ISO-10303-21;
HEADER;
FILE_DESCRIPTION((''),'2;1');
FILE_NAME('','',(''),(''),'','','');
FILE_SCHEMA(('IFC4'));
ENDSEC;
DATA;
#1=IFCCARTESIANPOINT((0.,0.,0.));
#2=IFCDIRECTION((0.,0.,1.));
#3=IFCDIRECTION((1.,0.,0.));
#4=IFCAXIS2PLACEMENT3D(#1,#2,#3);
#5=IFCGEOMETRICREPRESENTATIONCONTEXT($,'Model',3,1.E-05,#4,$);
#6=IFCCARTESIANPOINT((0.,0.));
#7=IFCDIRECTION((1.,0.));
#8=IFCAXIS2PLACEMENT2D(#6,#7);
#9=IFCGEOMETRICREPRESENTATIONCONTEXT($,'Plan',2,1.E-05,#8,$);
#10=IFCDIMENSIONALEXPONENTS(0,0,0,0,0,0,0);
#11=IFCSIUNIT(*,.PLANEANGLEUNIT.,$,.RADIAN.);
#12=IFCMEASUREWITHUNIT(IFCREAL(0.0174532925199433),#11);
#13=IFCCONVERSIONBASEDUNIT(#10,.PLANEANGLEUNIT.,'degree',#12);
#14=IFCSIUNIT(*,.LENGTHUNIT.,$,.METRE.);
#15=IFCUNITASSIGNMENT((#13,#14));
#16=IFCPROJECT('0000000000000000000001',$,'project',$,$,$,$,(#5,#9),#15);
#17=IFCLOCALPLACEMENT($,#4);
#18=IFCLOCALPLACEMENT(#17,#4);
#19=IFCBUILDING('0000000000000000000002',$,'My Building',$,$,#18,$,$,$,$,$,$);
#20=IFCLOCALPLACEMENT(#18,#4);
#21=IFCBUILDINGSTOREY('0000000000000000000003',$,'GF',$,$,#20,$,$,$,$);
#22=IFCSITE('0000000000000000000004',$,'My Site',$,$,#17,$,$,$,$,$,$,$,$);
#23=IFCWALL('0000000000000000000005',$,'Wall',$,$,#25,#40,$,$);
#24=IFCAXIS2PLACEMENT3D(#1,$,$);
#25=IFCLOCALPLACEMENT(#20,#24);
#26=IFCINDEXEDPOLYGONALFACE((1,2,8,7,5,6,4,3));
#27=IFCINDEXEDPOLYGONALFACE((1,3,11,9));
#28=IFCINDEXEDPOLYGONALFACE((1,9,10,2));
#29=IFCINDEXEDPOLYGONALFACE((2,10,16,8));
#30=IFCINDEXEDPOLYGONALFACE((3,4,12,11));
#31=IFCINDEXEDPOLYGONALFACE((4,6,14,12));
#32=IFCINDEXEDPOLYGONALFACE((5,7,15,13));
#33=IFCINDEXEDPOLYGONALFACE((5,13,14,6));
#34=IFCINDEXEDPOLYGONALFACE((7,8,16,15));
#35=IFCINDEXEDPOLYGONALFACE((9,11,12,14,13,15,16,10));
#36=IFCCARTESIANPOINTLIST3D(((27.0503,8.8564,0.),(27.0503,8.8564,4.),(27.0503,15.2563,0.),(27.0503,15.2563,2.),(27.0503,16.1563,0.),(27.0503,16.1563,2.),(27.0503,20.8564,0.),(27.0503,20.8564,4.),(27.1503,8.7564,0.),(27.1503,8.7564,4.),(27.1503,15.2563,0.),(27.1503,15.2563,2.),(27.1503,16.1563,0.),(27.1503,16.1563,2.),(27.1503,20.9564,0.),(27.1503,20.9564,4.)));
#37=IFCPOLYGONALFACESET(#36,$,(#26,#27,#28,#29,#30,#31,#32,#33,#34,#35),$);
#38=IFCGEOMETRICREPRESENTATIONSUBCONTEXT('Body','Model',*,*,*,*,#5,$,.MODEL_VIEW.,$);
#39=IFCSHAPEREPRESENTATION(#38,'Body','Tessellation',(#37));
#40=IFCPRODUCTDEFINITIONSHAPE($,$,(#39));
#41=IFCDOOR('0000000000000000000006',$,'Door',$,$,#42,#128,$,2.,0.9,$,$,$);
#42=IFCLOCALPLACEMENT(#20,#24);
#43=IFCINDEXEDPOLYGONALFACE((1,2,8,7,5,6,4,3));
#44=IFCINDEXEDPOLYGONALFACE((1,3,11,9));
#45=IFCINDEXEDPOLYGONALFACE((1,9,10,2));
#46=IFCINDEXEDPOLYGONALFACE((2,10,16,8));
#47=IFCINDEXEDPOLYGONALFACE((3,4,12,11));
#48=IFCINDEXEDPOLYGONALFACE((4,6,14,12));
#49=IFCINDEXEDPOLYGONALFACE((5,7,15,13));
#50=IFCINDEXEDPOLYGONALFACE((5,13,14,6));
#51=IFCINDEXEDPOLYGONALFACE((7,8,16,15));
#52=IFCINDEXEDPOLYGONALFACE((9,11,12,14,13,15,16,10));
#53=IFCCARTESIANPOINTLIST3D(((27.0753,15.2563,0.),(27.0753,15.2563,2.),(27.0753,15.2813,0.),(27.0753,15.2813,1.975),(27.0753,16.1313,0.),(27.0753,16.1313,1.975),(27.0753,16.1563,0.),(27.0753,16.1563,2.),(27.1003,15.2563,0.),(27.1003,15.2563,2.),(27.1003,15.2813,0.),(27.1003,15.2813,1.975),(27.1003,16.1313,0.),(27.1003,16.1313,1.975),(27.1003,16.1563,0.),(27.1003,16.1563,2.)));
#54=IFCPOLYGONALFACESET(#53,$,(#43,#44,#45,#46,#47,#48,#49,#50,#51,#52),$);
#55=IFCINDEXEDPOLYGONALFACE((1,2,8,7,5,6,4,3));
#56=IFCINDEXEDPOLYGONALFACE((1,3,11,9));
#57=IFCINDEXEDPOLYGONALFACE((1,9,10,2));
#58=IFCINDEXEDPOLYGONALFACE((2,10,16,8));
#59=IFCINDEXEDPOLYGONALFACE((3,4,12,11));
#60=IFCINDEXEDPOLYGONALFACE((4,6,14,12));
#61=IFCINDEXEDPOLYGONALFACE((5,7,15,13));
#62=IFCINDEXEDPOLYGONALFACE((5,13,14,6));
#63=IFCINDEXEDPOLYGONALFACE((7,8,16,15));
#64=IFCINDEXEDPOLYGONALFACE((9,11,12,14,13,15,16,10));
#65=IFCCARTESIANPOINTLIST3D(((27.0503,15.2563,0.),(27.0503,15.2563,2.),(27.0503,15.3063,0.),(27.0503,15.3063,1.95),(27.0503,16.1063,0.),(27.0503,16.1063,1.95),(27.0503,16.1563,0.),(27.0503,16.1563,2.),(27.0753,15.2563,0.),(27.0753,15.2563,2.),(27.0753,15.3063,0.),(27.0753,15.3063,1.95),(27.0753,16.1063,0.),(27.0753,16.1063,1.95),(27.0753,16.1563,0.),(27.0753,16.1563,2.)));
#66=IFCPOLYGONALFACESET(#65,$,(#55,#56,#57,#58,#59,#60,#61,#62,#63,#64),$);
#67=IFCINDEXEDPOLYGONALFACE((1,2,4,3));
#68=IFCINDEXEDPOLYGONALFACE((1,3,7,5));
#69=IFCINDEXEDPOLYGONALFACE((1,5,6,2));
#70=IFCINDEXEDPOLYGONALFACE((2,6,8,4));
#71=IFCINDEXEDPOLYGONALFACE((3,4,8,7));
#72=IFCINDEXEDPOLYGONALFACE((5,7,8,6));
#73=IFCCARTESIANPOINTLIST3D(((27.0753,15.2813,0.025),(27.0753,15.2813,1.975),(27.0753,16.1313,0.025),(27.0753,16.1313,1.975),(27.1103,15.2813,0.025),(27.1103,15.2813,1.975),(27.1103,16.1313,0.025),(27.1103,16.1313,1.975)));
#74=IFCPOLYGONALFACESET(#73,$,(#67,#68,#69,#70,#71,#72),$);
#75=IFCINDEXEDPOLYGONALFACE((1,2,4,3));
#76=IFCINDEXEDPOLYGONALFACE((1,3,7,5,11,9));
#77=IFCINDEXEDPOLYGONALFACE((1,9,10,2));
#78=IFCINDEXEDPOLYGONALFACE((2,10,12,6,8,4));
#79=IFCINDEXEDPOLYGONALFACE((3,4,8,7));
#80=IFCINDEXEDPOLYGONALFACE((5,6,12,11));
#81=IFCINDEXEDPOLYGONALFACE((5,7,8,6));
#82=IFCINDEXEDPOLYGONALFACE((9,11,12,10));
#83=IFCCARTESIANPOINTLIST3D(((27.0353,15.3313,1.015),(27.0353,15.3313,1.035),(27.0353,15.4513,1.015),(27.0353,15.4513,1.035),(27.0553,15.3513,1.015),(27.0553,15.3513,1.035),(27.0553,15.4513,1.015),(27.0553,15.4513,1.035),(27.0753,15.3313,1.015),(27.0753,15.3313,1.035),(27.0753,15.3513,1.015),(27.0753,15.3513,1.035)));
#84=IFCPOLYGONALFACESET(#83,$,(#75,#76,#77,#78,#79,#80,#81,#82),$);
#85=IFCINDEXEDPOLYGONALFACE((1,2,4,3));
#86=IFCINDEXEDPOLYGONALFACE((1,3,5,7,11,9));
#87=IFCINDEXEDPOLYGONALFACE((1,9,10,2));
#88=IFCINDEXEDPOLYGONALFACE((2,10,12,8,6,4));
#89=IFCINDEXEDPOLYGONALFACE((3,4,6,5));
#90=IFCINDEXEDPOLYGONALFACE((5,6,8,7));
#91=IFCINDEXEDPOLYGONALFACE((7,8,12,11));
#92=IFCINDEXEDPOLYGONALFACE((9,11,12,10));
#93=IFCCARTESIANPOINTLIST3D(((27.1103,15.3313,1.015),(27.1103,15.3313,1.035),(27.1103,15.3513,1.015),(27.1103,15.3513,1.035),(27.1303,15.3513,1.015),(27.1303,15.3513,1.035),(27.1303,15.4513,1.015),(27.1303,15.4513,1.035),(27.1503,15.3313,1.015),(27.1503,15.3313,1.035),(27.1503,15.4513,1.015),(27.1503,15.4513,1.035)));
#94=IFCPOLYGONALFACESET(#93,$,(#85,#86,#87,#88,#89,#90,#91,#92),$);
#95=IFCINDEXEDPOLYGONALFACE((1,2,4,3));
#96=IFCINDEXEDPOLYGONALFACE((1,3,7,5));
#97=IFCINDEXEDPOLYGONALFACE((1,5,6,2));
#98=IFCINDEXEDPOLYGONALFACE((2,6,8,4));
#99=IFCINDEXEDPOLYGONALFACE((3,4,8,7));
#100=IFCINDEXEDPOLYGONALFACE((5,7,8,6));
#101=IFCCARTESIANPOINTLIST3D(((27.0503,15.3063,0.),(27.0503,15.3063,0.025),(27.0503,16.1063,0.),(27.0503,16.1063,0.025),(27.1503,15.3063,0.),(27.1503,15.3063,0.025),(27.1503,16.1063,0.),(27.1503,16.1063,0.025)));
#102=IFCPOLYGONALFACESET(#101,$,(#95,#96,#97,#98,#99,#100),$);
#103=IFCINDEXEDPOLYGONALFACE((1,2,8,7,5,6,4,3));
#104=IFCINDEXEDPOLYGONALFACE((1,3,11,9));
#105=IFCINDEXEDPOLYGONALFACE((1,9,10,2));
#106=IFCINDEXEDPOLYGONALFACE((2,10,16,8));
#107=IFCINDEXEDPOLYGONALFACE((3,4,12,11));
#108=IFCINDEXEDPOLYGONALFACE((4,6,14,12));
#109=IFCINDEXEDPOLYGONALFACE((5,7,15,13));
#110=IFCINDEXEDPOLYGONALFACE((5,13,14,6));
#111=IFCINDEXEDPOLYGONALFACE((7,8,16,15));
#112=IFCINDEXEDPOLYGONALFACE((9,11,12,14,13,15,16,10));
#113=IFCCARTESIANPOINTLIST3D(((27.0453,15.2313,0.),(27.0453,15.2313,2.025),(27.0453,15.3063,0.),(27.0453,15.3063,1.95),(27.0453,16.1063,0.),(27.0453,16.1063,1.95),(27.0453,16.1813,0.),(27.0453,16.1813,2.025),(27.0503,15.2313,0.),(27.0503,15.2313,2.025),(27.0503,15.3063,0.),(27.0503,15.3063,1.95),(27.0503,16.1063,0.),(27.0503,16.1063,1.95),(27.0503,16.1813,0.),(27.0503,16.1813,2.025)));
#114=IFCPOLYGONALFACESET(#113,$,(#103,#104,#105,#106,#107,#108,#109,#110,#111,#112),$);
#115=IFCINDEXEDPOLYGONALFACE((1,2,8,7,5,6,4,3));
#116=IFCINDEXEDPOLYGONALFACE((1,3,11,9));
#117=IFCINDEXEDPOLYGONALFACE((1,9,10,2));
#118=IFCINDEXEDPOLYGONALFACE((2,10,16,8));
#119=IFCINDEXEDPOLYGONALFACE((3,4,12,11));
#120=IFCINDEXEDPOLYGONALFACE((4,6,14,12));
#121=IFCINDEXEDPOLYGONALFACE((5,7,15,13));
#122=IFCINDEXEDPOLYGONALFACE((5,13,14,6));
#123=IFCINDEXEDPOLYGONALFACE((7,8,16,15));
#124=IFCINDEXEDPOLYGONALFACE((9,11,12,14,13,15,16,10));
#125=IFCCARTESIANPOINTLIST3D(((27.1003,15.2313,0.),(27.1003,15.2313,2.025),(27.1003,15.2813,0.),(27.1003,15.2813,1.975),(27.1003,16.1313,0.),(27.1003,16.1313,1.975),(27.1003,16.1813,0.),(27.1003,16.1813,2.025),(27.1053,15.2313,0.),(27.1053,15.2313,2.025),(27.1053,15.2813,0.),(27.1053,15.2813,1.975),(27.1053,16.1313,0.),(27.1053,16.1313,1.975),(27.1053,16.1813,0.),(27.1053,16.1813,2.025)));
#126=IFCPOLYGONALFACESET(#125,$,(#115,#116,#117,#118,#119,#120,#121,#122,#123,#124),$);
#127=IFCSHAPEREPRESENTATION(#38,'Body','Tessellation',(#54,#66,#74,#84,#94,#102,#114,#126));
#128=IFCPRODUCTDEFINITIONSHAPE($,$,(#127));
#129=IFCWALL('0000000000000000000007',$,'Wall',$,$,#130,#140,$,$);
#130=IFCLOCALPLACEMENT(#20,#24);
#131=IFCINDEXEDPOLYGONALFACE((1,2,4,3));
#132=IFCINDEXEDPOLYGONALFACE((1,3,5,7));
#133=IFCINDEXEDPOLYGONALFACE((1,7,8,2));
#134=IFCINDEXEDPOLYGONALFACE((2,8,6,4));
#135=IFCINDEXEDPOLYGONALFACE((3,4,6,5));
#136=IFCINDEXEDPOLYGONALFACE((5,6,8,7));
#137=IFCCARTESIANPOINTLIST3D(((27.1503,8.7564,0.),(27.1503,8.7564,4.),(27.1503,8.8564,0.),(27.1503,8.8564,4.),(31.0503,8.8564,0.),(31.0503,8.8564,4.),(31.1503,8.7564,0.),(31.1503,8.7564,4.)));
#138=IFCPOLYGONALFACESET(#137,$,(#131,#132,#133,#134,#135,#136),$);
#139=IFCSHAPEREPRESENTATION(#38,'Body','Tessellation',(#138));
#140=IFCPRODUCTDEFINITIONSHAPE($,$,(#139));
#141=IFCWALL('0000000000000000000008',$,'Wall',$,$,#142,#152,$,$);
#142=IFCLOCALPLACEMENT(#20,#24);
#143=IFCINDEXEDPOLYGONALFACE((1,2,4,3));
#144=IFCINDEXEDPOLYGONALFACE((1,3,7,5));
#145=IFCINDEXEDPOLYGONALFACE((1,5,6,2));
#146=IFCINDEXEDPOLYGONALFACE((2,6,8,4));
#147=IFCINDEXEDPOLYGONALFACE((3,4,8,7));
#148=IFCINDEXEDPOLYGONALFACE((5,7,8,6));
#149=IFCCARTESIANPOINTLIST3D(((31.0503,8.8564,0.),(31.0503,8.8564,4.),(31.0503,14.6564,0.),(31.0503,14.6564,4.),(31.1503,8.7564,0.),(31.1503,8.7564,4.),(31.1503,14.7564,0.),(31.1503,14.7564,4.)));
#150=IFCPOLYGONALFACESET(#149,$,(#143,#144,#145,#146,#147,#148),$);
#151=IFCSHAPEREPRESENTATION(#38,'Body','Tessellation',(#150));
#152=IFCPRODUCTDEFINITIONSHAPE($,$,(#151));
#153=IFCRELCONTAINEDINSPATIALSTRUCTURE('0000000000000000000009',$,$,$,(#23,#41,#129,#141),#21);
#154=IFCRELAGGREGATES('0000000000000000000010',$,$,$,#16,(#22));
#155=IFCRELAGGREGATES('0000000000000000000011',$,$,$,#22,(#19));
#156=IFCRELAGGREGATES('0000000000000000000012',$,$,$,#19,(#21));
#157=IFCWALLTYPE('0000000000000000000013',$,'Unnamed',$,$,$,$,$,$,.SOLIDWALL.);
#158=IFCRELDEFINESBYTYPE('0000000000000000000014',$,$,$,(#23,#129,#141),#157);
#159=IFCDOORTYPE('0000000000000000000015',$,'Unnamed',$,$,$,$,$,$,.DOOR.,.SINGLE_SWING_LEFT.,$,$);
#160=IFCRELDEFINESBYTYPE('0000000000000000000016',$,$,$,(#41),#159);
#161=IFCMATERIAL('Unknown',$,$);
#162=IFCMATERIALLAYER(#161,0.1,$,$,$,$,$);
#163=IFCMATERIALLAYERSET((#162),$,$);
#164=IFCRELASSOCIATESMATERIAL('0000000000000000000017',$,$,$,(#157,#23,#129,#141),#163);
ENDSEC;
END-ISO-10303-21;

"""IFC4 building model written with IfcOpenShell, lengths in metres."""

from ifc_helpers import new_model, entity, si_unit, converted_unit, frame, origin_with_axes, origin_2d_with_axis, place, context, subcontext, project, spatial, line, indexed_curve, outline, extrude, shape, source, transform, mapped, material, layer, layer_set, layer_usage, type_object, type_shapes, element, fill, save


model = new_model("IFC4")

# Units and contexts
model_context = context("Model", 3, precision=1e-05, world=origin_with_axes())
plan_context = context("Plan", 2, precision=1e-05, world=origin_2d_with_axis())
body_context_1 = subcontext(model_context, "Body", "Model", "MODEL_VIEW")
body_context_2 = subcontext(plan_context, "Body", "Plan", "PLAN_VIEW")
ifc_project = project(units=[converted_unit("PLANEANGLEUNIT", "degree", entity("IfcReal", 0.0174532925199433), si_unit("PLANEANGLEUNIT", "RADIAN"), dimensions=[0, 0, 0, 0, 0, 0, 0]), si_unit("LENGTHUNIT", "METRE")], contexts=[model_context, plan_context])

# Site, building, storey
site_placement = place(None, origin_with_axes())
site = spatial("IfcSite", under=ifc_project, at=site_placement, Name="My Site")
building_placement = place(site_placement, origin_with_axes())
building = spatial("IfcBuilding", under=site, at=building_placement, Name="My Building")
storey_placement = place(building_placement, origin_with_axes())
storey = spatial("IfcBuildingStorey", under=building, at=storey_placement, Name="GF")

# Shared definitions
ifc_material = material(Name="Unknown")

# Wall, opening, door
ifc_layer_1 = layer(ifc_material, 0.1)
ifc_layer_set_1 = layer_set([ifc_layer_1])
ifc_layer_usage_1 = layer_usage(ifc_layer_set_1, "AXIS2", "POSITIVE", 0.0)
wall_type = type_object("IfcWallType", Name="Unnamed", PredefinedType="SOLIDWALL", material=ifc_layer_set_1)
wall_1_placement = place(storey_placement, frame((27.0503, 20.8564, 0.0), z_axis=(0.0, 0.0, 1.0), x_axis=(0.0, -1.0, 0.0)))
wall_1 = element("IfcWall", 1, at=wall_1_placement, inside=storey, type_object=wall_type, material=ifc_layer_usage_1, Name="Wall", context=body_context_1, shape_type="SweptSolid", body=[
    extrude(outline(indexed_curve([(0.0, 0.0), (-0.1, 0.1), (12.1, 0.1), (12.0, 0.0)], segments=[line(1, 2, 3, 4, 1)])), origin_with_axes(), (0.0, 0.0, 1.0), 4.0),
])
shared_shape_1 = source(origin_with_axes(), body_context_1, "Body", "SweptSolid", [
    extrude(outline(indexed_curve([(0.0, 0.0), (0.9, 0.0), (0.9, 2.0), (0.0, 2.0)], segments=[line(1, 2, 3, 4, 1)])), frame((0.0, -0.6, 0.0), z_axis=(0.0, -1.0, 0.0), x_axis=(1.0, 0.0, 0.0)), (0.0, 0.0, -1.0), 1.2),
])
opening_1_placement = place(wall_1_placement, frame((4.7001, 0.0, 0.0), z_axis=(0.0, 0.0, 1.0), x_axis=(1.0, 0.0, 0.0)))
opening_1 = element("IfcOpeningElement", 2, at=opening_1_placement, cuts=wall_1, PredefinedType="OPENING", context=body_context_1, shape_type="MappedRepresentation", body=[
    mapped(shared_shape_1, transform((0.0, 0.0, 0.0), x_axis=(1.0, 0.0, 0.0), y_axis=(0.0, 1.0, 0.0), z_axis=(0.0, 0.0, 1.0), scale=1.0)),
])
door_type = type_object("IfcDoorType", Name="Unnamed", OperationType="SINGLE_SWING_LEFT", PredefinedType="DOOR")
shared_shape_2 = source(origin_with_axes(), body_context_1, "Body", "SweptSolid", [
    extrude(outline(indexed_curve([(0.0, 0.0), (0.0, 2.0), (0.9, 2.0), (0.9, 0.0), (0.875, 0.0), (0.875, 1.975), (0.025, 1.975), (0.025, 0.0)], segments=[line(1, 2, 3, 4, 5, 6, 7, 8, 1)])), frame((0.0, 0.025, 0.0), z_axis=(0.0, -1.0, 0.0), x_axis=(1.0, 0.0, 0.0)), (0.0, 0.0, -1.0), 0.025),
    extrude(outline(indexed_curve([(0.0, 0.0), (0.0, 2.0), (0.9, 2.0), (0.9, 0.0), (0.85, 0.0), (0.85, 1.95), (0.05, 1.95), (0.05, 0.0)], segments=[line(1, 2, 3, 4, 5, 6, 7, 8, 1)])), frame((0.0, 0.0, 0.0), z_axis=(0.0, -1.0, 0.0), x_axis=(1.0, 0.0, 0.0)), (0.0, 0.0, -1.0), 0.025),
    extrude(outline(indexed_curve([(0.0, 0.0), (0.85, 0.0), (0.85, 0.035), (0.0, 0.035)], segments=[line(1, 2, 3, 4, 1)])), frame((0.025, 0.025, 0.025), z_axis=(0.0, 0.0, 1.0), x_axis=(1.0, 0.0, 0.0)), (0.0, 0.0, 1.0), 1.95),
    extrude(outline(indexed_curve([(0.0, 0.0), (0.0, -0.04), (-0.12, -0.04), (-0.12, -0.02), (-0.02, -0.02), (-0.02, 0.0)], segments=[line(1, 2, 3, 4, 5, 6, 1)])), frame((0.825, 0.025, 1.015), z_axis=(0.0, 0.0, 1.0), x_axis=(1.0, 0.0, 0.0)), (0.0, 0.0, 1.0), 0.02),
    extrude(outline(indexed_curve([(0.0, 0.0), (0.0, 0.04), (-0.12, 0.04), (-0.12, 0.02), (-0.02, 0.02), (-0.02, 0.0)], segments=[line(1, 2, 3, 4, 5, 6, 1)])), frame((0.825, 0.06, 1.015), z_axis=(0.0, 0.0, 1.0), x_axis=(1.0, 0.0, 0.0)), (0.0, 0.0, 1.0), 0.02),
    extrude(outline(indexed_curve([(0.0, 0.0), (0.8, 0.0), (0.8, 0.1), (0.0, 0.1)], segments=[line(1, 2, 3, 4, 1)])), frame((0.05, 0.0, 0.0), z_axis=(0.0, 0.0, 1.0), x_axis=(1.0, 0.0, 0.0)), (0.0, 0.0, 1.0), 0.025),
    extrude(outline(indexed_curve([(0.0, 0.0), (0.0, 2.025), (0.95, 2.025), (0.95, 0.0), (0.875, 0.0), (0.875, 1.95), (0.075, 1.95), (0.075, 0.0)], segments=[line(1, 2, 3, 4, 5, 6, 7, 8, 1)])), frame((-0.025, -0.005, 0.0), z_axis=(0.0, -1.0, 0.0), x_axis=(1.0, 0.0, 0.0)), (0.0, 0.0, -1.0), 0.005),
    extrude(outline(indexed_curve([(0.0, 0.0), (0.0, 2.025), (0.95, 2.025), (0.95, 0.0), (0.9, 0.0), (0.9, 1.975), (0.05, 1.975), (0.05, 0.0)], segments=[line(1, 2, 3, 4, 5, 6, 7, 8, 1)])), frame((-0.025, 0.05, 0.0), z_axis=(0.0, -1.0, 0.0), x_axis=(1.0, 0.0, 0.0)), (0.0, 0.0, -1.0), 0.005),
])
shared_shape_3 = source(origin_with_axes(), body_context_2, "Body", "Curve2D", [
    entity("IfcIndexedPolyCurve", entity("IfcCartesianPointList2D", [[0.0, 0.0], [0.0, 0.05], [0.025, 0.05], [0.025, 0.025], [0.05, 0.025], [0.05, 0.0]]), [entity("IfcLineIndex", [1, 2, 3, 4, 5, 6, 1])]),
    entity("IfcIndexedPolyCurve", entity("IfcCartesianPointList2D", [[0.9, 0.0], [0.9, 0.05], [0.875, 0.05], [0.875, 0.025], [0.85, 0.025], [0.85, 0.0]]), [entity("IfcLineIndex", [1, 2, 3, 4, 5, 6, 1])]),
    entity("IfcTrimmedCurve", entity("IfcEllipse", entity("IfcAxis2Placement2D", entity("IfcCartesianPoint", [0.06, 0.05]), entity("IfcDirection", [1.0, 0.0])), 0.815, 0.85), [entity("IfcCartesianPoint", [0.875, 0.05])], [entity("IfcCartesianPoint", [0.06, 0.9])], True, "CARTESIAN"),
    entity("IfcIndexedPolyCurve", entity("IfcCartesianPointList2D", [[0.025, 0.05], [0.06, 0.05], [0.06, 0.9], [0.025, 0.9]]), [entity("IfcLineIndex", [1, 2, 3, 4, 1])]),
])
type_shapes(door_type, [shared_shape_2, shared_shape_3])
door_1_placement = place(opening_1_placement, frame((0.0, 0.0, 0.0), z_axis=(0.0, 0.0, 1.0), x_axis=(1.0, 0.0, 0.0)))
door_1 = element("IfcDoor", 3, at=door_1_placement, inside=storey, type_object=door_type, Name="Door", OverallHeight=2.0, OverallWidth=0.9, shapes=[
    shape(body_context_1, "Body", "MappedRepresentation", [mapped(shared_shape_2, transform((0.0, 0.0, 0.0), x_axis=(1.0, 0.0, 0.0), y_axis=(0.0, 1.0, 0.0), z_axis=(0.0, 0.0, 1.0), scale=1.0))]),
    shape(body_context_2, "Body", "MappedRepresentation", [mapped(shared_shape_3, transform((0.0, 0.0, 0.0), x_axis=(1.0, 0.0, 0.0), y_axis=(0.0, 1.0, 0.0), z_axis=(0.0, 0.0, 1.0), scale=1.0))]),
])
fill(opening_1, door_1)

# Walls
ifc_layer_usage_2 = layer_usage(ifc_layer_set_1, "AXIS2", "POSITIVE", 0.0)
wall_2_placement = place(storey_placement, frame((27.1503, 8.7564, 0.0), z_axis=(0.0, 0.0, 1.0), x_axis=(1.0, 0.0, 0.0)))
element("IfcWall", 4, at=wall_2_placement, inside=storey, type_object=wall_type, material=ifc_layer_usage_2, Name="Wall", context=body_context_1, shape_type="SweptSolid", body=[
    extrude(outline(indexed_curve([(0.0, 0.0), (0.0, 0.1), (3.9, 0.1), (4.0, 0.0)], segments=[line(1, 2, 3, 4, 1)])), origin_with_axes(), (0.0, 0.0, 1.0), 4.0),
])
ifc_layer_usage_3 = layer_usage(ifc_layer_set_1, "AXIS2", "POSITIVE", 0.0)
wall_3_placement = place(storey_placement, frame((31.1503, 8.7564, 0.0), z_axis=(0.0, 0.0, 1.0), x_axis=(0.0, 1.0, 0.0)))
element("IfcWall", 5, at=wall_3_placement, inside=storey, type_object=wall_type, material=ifc_layer_usage_3, Name="Wall", context=body_context_1, shape_type="SweptSolid", body=[
    extrude(outline(indexed_curve([(0.0, 0.0), (0.1, 0.1), (5.9, 0.1), (6.0, 0.0)], segments=[line(1, 2, 3, 4, 1)])), origin_with_axes(), (0.0, 0.0, 1.0), 4.0),
])

save(model, "model.ifc")
